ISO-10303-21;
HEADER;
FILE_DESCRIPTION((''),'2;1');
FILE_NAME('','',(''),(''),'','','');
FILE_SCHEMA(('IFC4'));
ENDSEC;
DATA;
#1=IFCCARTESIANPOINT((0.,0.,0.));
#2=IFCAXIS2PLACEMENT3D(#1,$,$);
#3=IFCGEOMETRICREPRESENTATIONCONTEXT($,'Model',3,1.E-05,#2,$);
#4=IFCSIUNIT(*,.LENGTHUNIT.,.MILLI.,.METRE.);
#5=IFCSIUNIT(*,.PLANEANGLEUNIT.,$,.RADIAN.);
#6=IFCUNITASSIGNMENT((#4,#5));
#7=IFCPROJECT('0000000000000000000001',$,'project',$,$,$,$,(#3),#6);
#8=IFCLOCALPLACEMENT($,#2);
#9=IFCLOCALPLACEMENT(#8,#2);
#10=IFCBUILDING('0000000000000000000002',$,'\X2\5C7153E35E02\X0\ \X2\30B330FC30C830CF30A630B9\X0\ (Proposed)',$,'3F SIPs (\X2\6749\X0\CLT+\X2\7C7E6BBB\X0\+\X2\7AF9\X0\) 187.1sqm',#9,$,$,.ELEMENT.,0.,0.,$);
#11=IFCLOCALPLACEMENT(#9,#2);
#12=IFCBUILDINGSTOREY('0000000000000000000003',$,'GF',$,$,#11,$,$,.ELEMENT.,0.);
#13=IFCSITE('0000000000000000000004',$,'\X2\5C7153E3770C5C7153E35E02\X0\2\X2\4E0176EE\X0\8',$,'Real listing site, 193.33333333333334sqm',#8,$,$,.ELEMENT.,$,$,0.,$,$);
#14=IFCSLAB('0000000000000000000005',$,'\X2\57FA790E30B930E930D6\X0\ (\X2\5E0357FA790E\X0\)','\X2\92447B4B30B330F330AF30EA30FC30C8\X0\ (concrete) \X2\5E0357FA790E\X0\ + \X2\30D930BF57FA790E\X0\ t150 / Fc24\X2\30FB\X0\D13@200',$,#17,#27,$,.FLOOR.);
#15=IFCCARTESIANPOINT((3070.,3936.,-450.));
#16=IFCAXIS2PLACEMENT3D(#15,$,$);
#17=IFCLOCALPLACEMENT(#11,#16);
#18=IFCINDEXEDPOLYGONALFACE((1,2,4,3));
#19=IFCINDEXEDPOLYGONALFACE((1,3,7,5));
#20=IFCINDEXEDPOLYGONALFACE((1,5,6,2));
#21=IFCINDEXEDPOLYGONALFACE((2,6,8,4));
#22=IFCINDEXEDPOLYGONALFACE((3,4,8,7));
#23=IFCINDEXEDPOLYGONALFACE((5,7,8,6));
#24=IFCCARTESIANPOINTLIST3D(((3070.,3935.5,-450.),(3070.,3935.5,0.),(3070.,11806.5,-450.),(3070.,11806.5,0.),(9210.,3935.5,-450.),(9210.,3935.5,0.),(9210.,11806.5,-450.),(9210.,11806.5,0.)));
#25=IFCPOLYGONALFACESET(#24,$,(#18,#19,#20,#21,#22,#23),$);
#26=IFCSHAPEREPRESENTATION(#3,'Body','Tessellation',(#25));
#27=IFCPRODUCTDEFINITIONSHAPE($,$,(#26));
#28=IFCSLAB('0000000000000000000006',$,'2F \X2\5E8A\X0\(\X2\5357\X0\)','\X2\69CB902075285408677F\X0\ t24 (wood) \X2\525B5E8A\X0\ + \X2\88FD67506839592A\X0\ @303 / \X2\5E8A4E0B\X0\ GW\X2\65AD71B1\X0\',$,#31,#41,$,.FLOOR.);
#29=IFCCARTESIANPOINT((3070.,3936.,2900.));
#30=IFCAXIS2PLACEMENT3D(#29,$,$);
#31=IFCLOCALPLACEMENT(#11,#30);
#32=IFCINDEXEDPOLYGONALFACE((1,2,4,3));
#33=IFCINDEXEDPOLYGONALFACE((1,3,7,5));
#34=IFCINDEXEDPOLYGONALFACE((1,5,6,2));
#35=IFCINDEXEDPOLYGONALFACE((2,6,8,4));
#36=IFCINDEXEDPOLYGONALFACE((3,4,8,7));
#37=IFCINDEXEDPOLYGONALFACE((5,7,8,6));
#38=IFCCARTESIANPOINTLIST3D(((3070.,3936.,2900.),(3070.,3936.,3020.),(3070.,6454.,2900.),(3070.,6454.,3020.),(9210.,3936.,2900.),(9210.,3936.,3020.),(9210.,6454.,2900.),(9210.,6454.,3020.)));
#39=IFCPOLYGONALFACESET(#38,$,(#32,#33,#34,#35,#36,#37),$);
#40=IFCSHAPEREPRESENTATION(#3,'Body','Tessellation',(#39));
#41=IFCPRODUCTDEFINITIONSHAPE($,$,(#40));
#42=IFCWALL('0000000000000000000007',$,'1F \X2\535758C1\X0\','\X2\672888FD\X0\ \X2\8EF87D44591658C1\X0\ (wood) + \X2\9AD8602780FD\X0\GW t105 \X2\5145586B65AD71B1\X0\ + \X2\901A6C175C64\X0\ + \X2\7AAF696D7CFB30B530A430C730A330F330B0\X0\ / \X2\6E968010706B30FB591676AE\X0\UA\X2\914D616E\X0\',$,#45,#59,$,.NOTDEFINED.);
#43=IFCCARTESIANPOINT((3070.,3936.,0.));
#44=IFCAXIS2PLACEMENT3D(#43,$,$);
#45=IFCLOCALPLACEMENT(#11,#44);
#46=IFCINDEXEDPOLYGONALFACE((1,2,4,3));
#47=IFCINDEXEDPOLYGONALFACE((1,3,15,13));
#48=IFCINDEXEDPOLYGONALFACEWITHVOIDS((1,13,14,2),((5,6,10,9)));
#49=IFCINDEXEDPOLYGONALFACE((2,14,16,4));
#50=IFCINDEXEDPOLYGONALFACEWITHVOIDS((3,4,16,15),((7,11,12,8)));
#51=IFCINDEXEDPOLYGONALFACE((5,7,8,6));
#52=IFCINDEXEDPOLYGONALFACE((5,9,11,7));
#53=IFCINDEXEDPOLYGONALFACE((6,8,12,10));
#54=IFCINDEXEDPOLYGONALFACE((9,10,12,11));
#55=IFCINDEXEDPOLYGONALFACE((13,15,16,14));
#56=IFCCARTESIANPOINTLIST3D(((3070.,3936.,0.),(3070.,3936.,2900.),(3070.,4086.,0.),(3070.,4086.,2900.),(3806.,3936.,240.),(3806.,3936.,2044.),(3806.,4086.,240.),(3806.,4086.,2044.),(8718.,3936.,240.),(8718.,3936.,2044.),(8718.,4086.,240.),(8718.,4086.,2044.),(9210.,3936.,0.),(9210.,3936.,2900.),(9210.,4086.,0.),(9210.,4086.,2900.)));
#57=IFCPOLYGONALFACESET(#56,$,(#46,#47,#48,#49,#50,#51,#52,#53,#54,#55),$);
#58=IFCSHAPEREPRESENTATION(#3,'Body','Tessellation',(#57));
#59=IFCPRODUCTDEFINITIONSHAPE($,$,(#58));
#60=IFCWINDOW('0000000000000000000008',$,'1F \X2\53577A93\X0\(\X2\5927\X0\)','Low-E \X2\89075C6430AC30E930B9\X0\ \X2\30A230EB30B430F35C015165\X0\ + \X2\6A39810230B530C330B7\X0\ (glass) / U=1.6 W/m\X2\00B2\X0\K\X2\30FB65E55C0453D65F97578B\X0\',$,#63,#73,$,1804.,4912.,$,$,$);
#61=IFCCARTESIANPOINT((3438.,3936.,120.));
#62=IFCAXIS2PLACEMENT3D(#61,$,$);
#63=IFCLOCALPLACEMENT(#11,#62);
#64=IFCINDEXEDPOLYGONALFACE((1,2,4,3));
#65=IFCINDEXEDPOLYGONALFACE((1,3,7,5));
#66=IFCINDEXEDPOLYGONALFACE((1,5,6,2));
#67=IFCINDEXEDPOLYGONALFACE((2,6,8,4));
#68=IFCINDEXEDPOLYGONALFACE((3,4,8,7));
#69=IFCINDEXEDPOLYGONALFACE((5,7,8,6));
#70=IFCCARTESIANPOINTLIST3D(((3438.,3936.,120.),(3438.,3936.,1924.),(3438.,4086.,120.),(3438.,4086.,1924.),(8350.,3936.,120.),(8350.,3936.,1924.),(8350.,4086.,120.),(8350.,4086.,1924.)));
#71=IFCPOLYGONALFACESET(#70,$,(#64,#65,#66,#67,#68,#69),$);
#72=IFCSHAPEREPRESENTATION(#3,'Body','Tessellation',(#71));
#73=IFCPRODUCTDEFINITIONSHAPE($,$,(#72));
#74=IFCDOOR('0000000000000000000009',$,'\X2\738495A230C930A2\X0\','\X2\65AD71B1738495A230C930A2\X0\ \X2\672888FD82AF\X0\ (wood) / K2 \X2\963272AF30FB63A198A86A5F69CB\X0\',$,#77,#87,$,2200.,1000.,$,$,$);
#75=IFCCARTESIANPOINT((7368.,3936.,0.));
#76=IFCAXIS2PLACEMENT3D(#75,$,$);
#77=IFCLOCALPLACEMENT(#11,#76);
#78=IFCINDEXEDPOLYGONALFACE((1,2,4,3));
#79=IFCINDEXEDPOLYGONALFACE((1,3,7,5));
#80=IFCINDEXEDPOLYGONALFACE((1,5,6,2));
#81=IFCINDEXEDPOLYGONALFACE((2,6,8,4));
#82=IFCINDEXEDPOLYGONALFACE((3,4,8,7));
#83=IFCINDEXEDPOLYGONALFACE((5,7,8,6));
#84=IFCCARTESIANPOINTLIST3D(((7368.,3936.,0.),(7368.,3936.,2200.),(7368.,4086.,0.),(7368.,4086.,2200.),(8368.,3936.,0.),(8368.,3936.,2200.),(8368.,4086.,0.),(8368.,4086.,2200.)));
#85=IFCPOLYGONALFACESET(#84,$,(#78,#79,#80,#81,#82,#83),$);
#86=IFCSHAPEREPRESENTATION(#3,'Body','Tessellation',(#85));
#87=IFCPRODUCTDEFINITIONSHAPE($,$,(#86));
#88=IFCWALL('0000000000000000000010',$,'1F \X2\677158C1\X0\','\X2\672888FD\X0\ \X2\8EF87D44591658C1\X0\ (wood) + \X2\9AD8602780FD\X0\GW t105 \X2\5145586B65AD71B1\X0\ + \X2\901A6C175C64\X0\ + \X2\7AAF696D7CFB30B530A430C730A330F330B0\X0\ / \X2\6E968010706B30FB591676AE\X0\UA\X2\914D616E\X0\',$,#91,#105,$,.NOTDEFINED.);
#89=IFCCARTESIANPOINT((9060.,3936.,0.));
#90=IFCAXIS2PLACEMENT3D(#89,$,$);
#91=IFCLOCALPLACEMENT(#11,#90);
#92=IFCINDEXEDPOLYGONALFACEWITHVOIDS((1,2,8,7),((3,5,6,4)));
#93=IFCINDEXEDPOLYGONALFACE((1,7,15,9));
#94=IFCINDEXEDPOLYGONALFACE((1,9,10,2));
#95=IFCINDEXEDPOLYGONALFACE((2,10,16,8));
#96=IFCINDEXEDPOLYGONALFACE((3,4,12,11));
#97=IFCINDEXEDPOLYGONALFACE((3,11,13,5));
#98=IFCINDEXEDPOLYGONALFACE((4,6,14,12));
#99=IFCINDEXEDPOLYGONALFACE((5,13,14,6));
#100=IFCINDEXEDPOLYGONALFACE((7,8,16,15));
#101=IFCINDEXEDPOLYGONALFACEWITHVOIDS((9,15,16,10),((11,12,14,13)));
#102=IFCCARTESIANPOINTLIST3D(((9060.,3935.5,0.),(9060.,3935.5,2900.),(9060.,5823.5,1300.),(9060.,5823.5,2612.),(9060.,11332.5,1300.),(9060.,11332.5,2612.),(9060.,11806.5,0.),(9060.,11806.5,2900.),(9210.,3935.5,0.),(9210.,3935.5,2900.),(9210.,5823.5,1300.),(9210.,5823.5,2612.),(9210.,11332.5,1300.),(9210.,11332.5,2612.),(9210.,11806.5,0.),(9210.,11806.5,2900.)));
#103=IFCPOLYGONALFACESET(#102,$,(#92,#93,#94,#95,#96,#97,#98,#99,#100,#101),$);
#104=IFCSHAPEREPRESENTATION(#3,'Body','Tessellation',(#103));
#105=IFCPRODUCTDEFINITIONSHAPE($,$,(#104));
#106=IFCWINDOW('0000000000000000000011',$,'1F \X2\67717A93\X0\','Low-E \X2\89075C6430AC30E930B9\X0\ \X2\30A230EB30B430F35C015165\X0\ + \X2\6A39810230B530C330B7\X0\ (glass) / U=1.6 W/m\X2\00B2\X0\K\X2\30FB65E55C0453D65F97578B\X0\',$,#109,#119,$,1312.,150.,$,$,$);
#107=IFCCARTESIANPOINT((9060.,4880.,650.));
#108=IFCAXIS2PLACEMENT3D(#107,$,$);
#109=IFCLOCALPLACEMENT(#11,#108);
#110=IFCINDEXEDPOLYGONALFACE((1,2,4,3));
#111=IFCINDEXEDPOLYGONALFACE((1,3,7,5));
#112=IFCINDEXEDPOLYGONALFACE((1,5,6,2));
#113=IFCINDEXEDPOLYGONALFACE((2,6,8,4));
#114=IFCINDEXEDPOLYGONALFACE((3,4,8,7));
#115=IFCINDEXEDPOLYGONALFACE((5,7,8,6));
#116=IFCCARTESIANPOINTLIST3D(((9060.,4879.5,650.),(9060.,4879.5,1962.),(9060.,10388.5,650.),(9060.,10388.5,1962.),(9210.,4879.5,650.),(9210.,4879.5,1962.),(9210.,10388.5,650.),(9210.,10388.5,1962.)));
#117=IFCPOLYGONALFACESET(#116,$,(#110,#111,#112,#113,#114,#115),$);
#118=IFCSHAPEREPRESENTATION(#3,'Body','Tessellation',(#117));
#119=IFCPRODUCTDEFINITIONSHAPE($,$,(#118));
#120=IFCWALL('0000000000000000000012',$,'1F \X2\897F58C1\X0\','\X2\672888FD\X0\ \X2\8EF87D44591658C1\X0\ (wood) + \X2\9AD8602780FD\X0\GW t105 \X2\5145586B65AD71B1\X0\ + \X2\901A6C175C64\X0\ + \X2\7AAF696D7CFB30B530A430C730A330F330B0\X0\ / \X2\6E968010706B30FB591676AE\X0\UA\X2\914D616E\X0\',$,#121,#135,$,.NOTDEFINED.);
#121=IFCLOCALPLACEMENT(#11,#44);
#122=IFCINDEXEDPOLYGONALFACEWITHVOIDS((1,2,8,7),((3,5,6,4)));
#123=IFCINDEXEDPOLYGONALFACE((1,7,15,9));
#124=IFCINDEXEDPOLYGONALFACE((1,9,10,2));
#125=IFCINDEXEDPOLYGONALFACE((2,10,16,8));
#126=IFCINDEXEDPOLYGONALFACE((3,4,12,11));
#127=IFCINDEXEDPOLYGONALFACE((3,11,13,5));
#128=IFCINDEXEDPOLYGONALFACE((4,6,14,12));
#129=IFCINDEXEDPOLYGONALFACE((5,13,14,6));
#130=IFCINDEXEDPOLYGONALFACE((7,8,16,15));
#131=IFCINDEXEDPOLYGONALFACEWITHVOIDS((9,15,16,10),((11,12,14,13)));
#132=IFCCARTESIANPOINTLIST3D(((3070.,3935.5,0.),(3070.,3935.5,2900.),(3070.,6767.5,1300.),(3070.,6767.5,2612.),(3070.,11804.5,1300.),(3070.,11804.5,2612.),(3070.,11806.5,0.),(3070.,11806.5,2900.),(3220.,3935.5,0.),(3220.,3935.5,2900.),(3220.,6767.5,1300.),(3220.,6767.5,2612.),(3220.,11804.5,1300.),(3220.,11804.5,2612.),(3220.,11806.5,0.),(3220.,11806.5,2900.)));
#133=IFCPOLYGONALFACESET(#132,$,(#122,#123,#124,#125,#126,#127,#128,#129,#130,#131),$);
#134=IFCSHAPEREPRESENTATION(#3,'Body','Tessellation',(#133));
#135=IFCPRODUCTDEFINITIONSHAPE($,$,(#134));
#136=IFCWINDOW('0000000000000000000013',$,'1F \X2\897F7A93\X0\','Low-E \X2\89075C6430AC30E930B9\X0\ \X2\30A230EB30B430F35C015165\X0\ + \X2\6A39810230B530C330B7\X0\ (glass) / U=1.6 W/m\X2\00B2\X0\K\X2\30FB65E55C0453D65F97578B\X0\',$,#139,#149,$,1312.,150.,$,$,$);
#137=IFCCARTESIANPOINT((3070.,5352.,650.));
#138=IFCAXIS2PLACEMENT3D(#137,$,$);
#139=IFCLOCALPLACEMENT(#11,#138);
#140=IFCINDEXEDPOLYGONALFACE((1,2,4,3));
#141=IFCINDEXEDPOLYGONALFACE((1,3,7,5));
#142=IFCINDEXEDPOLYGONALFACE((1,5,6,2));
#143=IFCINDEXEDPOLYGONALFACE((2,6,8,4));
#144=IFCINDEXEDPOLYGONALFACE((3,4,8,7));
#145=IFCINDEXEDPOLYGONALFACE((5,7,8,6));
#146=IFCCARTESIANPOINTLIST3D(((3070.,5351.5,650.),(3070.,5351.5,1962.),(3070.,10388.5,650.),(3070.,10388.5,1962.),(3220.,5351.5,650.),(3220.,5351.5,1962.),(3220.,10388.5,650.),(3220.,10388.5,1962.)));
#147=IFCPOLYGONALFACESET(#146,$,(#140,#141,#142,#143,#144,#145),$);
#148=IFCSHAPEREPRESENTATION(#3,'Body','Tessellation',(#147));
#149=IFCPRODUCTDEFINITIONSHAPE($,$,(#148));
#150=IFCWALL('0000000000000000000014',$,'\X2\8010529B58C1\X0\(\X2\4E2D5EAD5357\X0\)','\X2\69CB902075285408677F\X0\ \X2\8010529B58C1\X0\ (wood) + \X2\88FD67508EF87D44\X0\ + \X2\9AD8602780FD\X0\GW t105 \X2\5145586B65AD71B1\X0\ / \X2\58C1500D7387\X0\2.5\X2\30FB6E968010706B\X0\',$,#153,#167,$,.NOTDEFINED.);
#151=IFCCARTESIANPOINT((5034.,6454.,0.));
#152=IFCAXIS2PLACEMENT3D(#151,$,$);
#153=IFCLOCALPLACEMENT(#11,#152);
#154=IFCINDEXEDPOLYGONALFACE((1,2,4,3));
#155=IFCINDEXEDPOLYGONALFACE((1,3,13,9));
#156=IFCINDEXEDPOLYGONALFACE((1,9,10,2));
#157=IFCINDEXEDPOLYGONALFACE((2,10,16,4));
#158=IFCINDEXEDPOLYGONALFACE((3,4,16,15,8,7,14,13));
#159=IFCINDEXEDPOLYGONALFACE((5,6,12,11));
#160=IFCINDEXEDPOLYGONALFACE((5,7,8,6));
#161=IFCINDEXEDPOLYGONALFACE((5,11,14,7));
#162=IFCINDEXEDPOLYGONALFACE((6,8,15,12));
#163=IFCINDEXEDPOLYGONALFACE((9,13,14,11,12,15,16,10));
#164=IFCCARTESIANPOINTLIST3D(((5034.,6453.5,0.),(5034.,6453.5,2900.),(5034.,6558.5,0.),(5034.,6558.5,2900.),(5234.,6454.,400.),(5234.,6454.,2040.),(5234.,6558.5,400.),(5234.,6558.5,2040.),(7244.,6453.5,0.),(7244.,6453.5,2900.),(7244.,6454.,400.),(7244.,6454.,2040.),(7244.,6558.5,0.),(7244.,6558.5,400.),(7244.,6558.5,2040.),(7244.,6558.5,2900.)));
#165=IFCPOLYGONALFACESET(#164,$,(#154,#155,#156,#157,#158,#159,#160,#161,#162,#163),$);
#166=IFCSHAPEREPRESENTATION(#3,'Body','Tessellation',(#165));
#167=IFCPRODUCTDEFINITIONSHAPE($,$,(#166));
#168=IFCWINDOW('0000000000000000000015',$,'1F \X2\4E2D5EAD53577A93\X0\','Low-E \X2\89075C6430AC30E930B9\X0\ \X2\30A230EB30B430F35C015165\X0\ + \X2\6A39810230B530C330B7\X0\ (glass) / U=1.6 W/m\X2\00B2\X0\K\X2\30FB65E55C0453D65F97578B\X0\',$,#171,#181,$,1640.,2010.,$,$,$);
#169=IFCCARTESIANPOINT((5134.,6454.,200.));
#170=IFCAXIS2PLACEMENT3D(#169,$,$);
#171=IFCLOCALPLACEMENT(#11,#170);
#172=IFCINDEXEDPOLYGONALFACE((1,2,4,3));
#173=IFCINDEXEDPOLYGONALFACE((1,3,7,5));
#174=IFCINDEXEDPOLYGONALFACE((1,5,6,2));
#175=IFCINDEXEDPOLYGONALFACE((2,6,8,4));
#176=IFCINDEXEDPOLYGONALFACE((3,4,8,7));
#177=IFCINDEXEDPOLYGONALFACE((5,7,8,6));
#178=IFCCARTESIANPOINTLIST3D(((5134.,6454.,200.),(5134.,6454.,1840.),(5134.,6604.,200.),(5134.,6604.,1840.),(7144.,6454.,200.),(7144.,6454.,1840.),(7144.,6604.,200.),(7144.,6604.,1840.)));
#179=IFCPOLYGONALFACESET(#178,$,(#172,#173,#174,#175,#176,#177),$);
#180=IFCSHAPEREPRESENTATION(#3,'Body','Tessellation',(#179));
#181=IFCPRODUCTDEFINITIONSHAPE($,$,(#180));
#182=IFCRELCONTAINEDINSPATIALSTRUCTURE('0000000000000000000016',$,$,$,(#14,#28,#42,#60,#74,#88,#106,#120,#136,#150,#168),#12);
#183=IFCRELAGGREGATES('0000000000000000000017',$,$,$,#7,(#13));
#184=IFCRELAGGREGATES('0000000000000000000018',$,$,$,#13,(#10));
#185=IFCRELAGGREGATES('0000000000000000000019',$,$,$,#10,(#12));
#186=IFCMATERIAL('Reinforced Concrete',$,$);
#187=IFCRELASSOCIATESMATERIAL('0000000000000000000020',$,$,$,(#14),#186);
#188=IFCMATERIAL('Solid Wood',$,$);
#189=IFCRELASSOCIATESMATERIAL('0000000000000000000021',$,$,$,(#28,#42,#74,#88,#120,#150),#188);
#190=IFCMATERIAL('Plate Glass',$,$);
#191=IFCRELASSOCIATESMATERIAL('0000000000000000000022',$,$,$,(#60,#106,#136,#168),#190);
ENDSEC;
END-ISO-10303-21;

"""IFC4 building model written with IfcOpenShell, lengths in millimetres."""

from ifc_helpers import new_model, si_unit, frame, frame_2d, origin, place, context, project, spatial, rectangle, extrude, material, element, fill, save


model = new_model("IFC4")

# Units and contexts
model_context = context("Model", 3, precision=1e-05, world=origin())
ifc_project = project(units=[si_unit("LENGTHUNIT", "METRE", prefix="MILLI"), si_unit("PLANEANGLEUNIT", "RADIAN")], contexts=[model_context])

# Site, building, storey
site_placement = place(None, origin())
site = spatial("IfcSite", under=ifc_project, at=site_placement, Name="山口県山口市2丁目8", ObjectType="Real listing site, 193.33333333333334sqm", CompositionType="ELEMENT", RefElevation=0.0)
building_placement = place(site_placement, origin())
building = spatial("IfcBuilding", under=site, at=building_placement, Name="山口市 コートハウス (Proposed)", ObjectType="3F SIPs (杉CLT+籾殻+竹) 187.1sqm", CompositionType="ELEMENT", ElevationOfRefHeight=0.0, ElevationOfTerrain=0.0)
storey_placement = place(building_placement, origin())
storey = spatial("IfcBuildingStorey", under=building, at=storey_placement, Name="GF", CompositionType="ELEMENT", Elevation=0.0)

# Slabs
ifc_material_1 = material(Name="Reinforced Concrete")
slab_1_placement = place(storey_placement, frame((3070.0, 3936.0, -450.0)))
element("IfcSlab", 1, at=slab_1_placement, inside=storey, material=ifc_material_1, Name="基礎スラブ (布基礎)", Description="鉄筋コンクリート (concrete) 布基礎 + ベタ基礎 t150 / Fc24・D13@200", PredefinedType="FLOOR", context=model_context, shape_type="SweptSolid", body=[
    extrude(rectangle(XDim=6140.0, YDim=7871.0, at=frame_2d((3070.0, 3935.0))), frame((3070.0, 3936.0, -450.0)), (0.0, 0.0, 1.0), 450.0),
])
ifc_material_2 = material(Name="Solid Wood")
slab_2_placement = place(storey_placement, frame((3070.0, 3936.0, 2900.0)))
element("IfcSlab", 2, at=slab_2_placement, inside=storey, material=ifc_material_2, Name="2F 床(南)", Description="構造用合板 t24 (wood) 剛床 + 製材根太 @303 / 床下 GW断熱", PredefinedType="FLOOR", context=model_context, shape_type="SweptSolid", body=[
    extrude(rectangle(XDim=6140.0, YDim=2518.0, at=frame_2d((3070.0, 1259.0))), frame((3070.0, 3936.0, 2900.0)), (0.0, 0.0, 1.0), 120.0),
])

# Wall, openings, window, door
wall_1_placement = place(storey_placement, frame((3070.0, 3936.0, 0.0)))
wall_1 = element("IfcWall", 3, at=wall_1_placement, inside=storey, material=ifc_material_2, Name="1F 南壁", Description="木製 軸組外壁 (wood) + 高性能GW t105 充填断熱 + 通気層 + 窯業系サイディング / 準耐火・外皮UA配慮", PredefinedType="NOTDEFINED", context=model_context, shape_type="SweptSolid", body=[
    extrude(rectangle(XDim=6140.0, YDim=150.0, at=frame_2d((3070.0, 75.0))), frame((3070.0, 3936.0, 0.0)), (0.0, 0.0, 1.0), 2900.0),
])
opening_1_placement = place(storey_placement, frame((3438.0, 3936.0, 120.0)))
opening_1 = element("IfcOpeningElement", 4, at=opening_1_placement, cuts=wall_1, PredefinedType="NOTDEFINED", context=model_context, shape_type="SweptSolid", body=[
    extrude(rectangle(XDim=4912.0, YDim=150.0, at=frame_2d((2456.0, 75.0))), frame((3438.0, 3936.0, 120.0)), (0.0, 0.0, 1.0), 1804.0),
])
opening_2_placement = place(storey_placement, frame((7368.0, 3936.0, 0.0)))
opening_2 = element("IfcOpeningElement", 5, at=opening_2_placement, cuts=wall_1, PredefinedType="NOTDEFINED", context=model_context, shape_type="SweptSolid", body=[
    extrude(rectangle(XDim=1000.0, YDim=150.0, at=frame_2d((500.0, 75.0))), frame((7368.0, 3936.0, 0.0)), (0.0, 0.0, 1.0), 2200.0),
])
ifc_material_3 = material(Name="Plate Glass")
window_1_placement = place(storey_placement, frame((3438.0, 3936.0, 120.0)))
window_1 = element("IfcWindow", 6, at=window_1_placement, inside=storey, material=ifc_material_3, Name="1F 南窓(大)", Description="Low-E 複層ガラス アルゴン封入 + 樹脂サッシ (glass) / U=1.6 W/m²K・日射取得型", OverallHeight=1804.0, OverallWidth=4912.0, context=model_context, shape_type="SweptSolid", body=[
    extrude(rectangle(XDim=4912.0, YDim=150.0, at=frame_2d((2456.0, 75.0))), frame((3438.0, 3936.0, 120.0)), (0.0, 0.0, 1.0), 1804.0),
])
fill(opening_1, window_1)
door_placement = place(storey_placement, frame((7368.0, 3936.0, 0.0)))
door = element("IfcDoor", 7, at=door_placement, inside=storey, material=ifc_material_2, Name="玄関ドア", Description="断熱玄関ドア 木製芯 (wood) / K2 防犯・採風機構", OverallHeight=2200.0, OverallWidth=1000.0, context=model_context, shape_type="SweptSolid", body=[
    extrude(rectangle(XDim=1000.0, YDim=150.0, at=frame_2d((500.0, 75.0))), frame((7368.0, 3936.0, 0.0)), (0.0, 0.0, 1.0), 2200.0),
])
fill(opening_2, door)

# Walls, openings, windows
wall_2_placement = place(storey_placement, frame((9060.0, 3936.0, 0.0)))
wall_2 = element("IfcWall", 8, at=wall_2_placement, inside=storey, material=ifc_material_2, Name="1F 東壁", Description="木製 軸組外壁 (wood) + 高性能GW t105 充填断熱 + 通気層 + 窯業系サイディング / 準耐火・外皮UA配慮", PredefinedType="NOTDEFINED", context=model_context, shape_type="SweptSolid", body=[
    extrude(rectangle(XDim=150.0, YDim=7871.0, at=frame_2d((75.0, 3935.0))), frame((9060.0, 3936.0, 0.0)), (0.0, 0.0, 1.0), 2900.0),
])
opening_3_placement = place(storey_placement, frame((9060.0, 4880.0, 650.0)))
opening_3 = element("IfcOpeningElement", 9, at=opening_3_placement, cuts=wall_2, PredefinedType="NOTDEFINED", context=model_context, shape_type="SweptSolid", body=[
    extrude(rectangle(XDim=150.0, YDim=5509.0, at=frame_2d((75.0, 2754.0))), frame((9060.0, 4880.0, 650.0)), (0.0, 0.0, 1.0), 1312.0),
])
window_2_placement = place(storey_placement, frame((9060.0, 4880.0, 650.0)))
window_2 = element("IfcWindow", 10, at=window_2_placement, inside=storey, material=ifc_material_3, Name="1F 東窓", Description="Low-E 複層ガラス アルゴン封入 + 樹脂サッシ (glass) / U=1.6 W/m²K・日射取得型", OverallHeight=1312.0, OverallWidth=150.0, context=model_context, shape_type="SweptSolid", body=[
    extrude(rectangle(XDim=150.0, YDim=5509.0, at=frame_2d((75.0, 2754.0))), frame((9060.0, 4880.0, 650.0)), (0.0, 0.0, 1.0), 1312.0),
])
fill(opening_3, window_2)
wall_3_placement = place(storey_placement, frame((3070.0, 3936.0, 0.0)))
wall_3 = element("IfcWall", 11, at=wall_3_placement, inside=storey, material=ifc_material_2, Name="1F 西壁", Description="木製 軸組外壁 (wood) + 高性能GW t105 充填断熱 + 通気層 + 窯業系サイディング / 準耐火・外皮UA配慮", PredefinedType="NOTDEFINED", context=model_context, shape_type="SweptSolid", body=[
    extrude(rectangle(XDim=150.0, YDim=7871.0, at=frame_2d((75.0, 3935.0))), frame((3070.0, 3936.0, 0.0)), (0.0, 0.0, 1.0), 2900.0),
])
opening_4_placement = place(storey_placement, frame((3070.0, 5352.0, 650.0)))
opening_4 = element("IfcOpeningElement", 12, at=opening_4_placement, cuts=wall_3, PredefinedType="NOTDEFINED", context=model_context, shape_type="SweptSolid", body=[
    extrude(rectangle(XDim=150.0, YDim=5037.0, at=frame_2d((75.0, 2518.0))), frame((3070.0, 5352.0, 650.0)), (0.0, 0.0, 1.0), 1312.0),
])
window_3_placement = place(storey_placement, frame((3070.0, 5352.0, 650.0)))
window_3 = element("IfcWindow", 13, at=window_3_placement, inside=storey, material=ifc_material_3, Name="1F 西窓", Description="Low-E 複層ガラス アルゴン封入 + 樹脂サッシ (glass) / U=1.6 W/m²K・日射取得型", OverallHeight=1312.0, OverallWidth=150.0, context=model_context, shape_type="SweptSolid", body=[
    extrude(rectangle(XDim=150.0, YDim=5037.0, at=frame_2d((75.0, 2518.0))), frame((3070.0, 5352.0, 650.0)), (0.0, 0.0, 1.0), 1312.0),
])
fill(opening_4, window_3)
wall_4_placement = place(storey_placement, frame((5034.0, 6454.0, 0.0)))
wall_4 = element("IfcWall", 14, at=wall_4_placement, inside=storey, material=ifc_material_2, Name="耐力壁(中庭南)", Description="構造用合板 耐力壁 (wood) + 製材軸組 + 高性能GW t105 充填断熱 / 壁倍率2.5・準耐火", PredefinedType="NOTDEFINED", context=model_context, shape_type="SweptSolid", body=[
    extrude(rectangle(XDim=2210.0, YDim=105.0, at=frame_2d((1105.0, 52.0))), frame((5034.0, 6454.0, 0.0)), (0.0, 0.0, 1.0), 2900.0),
])
opening_5_placement = place(storey_placement, frame((5134.0, 6454.0, 200.0)))
opening_5 = element("IfcOpeningElement", 15, at=opening_5_placement, cuts=wall_4, PredefinedType="NOTDEFINED", context=model_context, shape_type="SweptSolid", body=[
    extrude(rectangle(XDim=2010.0, YDim=150.0, at=frame_2d((1005.0, 75.0))), frame((5134.0, 6454.0, 200.0)), (0.0, 0.0, 1.0), 1640.0),
])
window_4_placement = place(storey_placement, frame((5134.0, 6454.0, 200.0)))
window_4 = element("IfcWindow", 16, at=window_4_placement, inside=storey, material=ifc_material_3, Name="1F 中庭南窓", Description="Low-E 複層ガラス アルゴン封入 + 樹脂サッシ (glass) / U=1.6 W/m²K・日射取得型", OverallHeight=1640.0, OverallWidth=2010.0, context=model_context, shape_type="SweptSolid", body=[
    extrude(rectangle(XDim=2010.0, YDim=150.0, at=frame_2d((1005.0, 75.0))), frame((5134.0, 6454.0, 200.0)), (0.0, 0.0, 1.0), 1640.0),
])
fill(opening_5, window_4)

save(model, "model.ifc")
